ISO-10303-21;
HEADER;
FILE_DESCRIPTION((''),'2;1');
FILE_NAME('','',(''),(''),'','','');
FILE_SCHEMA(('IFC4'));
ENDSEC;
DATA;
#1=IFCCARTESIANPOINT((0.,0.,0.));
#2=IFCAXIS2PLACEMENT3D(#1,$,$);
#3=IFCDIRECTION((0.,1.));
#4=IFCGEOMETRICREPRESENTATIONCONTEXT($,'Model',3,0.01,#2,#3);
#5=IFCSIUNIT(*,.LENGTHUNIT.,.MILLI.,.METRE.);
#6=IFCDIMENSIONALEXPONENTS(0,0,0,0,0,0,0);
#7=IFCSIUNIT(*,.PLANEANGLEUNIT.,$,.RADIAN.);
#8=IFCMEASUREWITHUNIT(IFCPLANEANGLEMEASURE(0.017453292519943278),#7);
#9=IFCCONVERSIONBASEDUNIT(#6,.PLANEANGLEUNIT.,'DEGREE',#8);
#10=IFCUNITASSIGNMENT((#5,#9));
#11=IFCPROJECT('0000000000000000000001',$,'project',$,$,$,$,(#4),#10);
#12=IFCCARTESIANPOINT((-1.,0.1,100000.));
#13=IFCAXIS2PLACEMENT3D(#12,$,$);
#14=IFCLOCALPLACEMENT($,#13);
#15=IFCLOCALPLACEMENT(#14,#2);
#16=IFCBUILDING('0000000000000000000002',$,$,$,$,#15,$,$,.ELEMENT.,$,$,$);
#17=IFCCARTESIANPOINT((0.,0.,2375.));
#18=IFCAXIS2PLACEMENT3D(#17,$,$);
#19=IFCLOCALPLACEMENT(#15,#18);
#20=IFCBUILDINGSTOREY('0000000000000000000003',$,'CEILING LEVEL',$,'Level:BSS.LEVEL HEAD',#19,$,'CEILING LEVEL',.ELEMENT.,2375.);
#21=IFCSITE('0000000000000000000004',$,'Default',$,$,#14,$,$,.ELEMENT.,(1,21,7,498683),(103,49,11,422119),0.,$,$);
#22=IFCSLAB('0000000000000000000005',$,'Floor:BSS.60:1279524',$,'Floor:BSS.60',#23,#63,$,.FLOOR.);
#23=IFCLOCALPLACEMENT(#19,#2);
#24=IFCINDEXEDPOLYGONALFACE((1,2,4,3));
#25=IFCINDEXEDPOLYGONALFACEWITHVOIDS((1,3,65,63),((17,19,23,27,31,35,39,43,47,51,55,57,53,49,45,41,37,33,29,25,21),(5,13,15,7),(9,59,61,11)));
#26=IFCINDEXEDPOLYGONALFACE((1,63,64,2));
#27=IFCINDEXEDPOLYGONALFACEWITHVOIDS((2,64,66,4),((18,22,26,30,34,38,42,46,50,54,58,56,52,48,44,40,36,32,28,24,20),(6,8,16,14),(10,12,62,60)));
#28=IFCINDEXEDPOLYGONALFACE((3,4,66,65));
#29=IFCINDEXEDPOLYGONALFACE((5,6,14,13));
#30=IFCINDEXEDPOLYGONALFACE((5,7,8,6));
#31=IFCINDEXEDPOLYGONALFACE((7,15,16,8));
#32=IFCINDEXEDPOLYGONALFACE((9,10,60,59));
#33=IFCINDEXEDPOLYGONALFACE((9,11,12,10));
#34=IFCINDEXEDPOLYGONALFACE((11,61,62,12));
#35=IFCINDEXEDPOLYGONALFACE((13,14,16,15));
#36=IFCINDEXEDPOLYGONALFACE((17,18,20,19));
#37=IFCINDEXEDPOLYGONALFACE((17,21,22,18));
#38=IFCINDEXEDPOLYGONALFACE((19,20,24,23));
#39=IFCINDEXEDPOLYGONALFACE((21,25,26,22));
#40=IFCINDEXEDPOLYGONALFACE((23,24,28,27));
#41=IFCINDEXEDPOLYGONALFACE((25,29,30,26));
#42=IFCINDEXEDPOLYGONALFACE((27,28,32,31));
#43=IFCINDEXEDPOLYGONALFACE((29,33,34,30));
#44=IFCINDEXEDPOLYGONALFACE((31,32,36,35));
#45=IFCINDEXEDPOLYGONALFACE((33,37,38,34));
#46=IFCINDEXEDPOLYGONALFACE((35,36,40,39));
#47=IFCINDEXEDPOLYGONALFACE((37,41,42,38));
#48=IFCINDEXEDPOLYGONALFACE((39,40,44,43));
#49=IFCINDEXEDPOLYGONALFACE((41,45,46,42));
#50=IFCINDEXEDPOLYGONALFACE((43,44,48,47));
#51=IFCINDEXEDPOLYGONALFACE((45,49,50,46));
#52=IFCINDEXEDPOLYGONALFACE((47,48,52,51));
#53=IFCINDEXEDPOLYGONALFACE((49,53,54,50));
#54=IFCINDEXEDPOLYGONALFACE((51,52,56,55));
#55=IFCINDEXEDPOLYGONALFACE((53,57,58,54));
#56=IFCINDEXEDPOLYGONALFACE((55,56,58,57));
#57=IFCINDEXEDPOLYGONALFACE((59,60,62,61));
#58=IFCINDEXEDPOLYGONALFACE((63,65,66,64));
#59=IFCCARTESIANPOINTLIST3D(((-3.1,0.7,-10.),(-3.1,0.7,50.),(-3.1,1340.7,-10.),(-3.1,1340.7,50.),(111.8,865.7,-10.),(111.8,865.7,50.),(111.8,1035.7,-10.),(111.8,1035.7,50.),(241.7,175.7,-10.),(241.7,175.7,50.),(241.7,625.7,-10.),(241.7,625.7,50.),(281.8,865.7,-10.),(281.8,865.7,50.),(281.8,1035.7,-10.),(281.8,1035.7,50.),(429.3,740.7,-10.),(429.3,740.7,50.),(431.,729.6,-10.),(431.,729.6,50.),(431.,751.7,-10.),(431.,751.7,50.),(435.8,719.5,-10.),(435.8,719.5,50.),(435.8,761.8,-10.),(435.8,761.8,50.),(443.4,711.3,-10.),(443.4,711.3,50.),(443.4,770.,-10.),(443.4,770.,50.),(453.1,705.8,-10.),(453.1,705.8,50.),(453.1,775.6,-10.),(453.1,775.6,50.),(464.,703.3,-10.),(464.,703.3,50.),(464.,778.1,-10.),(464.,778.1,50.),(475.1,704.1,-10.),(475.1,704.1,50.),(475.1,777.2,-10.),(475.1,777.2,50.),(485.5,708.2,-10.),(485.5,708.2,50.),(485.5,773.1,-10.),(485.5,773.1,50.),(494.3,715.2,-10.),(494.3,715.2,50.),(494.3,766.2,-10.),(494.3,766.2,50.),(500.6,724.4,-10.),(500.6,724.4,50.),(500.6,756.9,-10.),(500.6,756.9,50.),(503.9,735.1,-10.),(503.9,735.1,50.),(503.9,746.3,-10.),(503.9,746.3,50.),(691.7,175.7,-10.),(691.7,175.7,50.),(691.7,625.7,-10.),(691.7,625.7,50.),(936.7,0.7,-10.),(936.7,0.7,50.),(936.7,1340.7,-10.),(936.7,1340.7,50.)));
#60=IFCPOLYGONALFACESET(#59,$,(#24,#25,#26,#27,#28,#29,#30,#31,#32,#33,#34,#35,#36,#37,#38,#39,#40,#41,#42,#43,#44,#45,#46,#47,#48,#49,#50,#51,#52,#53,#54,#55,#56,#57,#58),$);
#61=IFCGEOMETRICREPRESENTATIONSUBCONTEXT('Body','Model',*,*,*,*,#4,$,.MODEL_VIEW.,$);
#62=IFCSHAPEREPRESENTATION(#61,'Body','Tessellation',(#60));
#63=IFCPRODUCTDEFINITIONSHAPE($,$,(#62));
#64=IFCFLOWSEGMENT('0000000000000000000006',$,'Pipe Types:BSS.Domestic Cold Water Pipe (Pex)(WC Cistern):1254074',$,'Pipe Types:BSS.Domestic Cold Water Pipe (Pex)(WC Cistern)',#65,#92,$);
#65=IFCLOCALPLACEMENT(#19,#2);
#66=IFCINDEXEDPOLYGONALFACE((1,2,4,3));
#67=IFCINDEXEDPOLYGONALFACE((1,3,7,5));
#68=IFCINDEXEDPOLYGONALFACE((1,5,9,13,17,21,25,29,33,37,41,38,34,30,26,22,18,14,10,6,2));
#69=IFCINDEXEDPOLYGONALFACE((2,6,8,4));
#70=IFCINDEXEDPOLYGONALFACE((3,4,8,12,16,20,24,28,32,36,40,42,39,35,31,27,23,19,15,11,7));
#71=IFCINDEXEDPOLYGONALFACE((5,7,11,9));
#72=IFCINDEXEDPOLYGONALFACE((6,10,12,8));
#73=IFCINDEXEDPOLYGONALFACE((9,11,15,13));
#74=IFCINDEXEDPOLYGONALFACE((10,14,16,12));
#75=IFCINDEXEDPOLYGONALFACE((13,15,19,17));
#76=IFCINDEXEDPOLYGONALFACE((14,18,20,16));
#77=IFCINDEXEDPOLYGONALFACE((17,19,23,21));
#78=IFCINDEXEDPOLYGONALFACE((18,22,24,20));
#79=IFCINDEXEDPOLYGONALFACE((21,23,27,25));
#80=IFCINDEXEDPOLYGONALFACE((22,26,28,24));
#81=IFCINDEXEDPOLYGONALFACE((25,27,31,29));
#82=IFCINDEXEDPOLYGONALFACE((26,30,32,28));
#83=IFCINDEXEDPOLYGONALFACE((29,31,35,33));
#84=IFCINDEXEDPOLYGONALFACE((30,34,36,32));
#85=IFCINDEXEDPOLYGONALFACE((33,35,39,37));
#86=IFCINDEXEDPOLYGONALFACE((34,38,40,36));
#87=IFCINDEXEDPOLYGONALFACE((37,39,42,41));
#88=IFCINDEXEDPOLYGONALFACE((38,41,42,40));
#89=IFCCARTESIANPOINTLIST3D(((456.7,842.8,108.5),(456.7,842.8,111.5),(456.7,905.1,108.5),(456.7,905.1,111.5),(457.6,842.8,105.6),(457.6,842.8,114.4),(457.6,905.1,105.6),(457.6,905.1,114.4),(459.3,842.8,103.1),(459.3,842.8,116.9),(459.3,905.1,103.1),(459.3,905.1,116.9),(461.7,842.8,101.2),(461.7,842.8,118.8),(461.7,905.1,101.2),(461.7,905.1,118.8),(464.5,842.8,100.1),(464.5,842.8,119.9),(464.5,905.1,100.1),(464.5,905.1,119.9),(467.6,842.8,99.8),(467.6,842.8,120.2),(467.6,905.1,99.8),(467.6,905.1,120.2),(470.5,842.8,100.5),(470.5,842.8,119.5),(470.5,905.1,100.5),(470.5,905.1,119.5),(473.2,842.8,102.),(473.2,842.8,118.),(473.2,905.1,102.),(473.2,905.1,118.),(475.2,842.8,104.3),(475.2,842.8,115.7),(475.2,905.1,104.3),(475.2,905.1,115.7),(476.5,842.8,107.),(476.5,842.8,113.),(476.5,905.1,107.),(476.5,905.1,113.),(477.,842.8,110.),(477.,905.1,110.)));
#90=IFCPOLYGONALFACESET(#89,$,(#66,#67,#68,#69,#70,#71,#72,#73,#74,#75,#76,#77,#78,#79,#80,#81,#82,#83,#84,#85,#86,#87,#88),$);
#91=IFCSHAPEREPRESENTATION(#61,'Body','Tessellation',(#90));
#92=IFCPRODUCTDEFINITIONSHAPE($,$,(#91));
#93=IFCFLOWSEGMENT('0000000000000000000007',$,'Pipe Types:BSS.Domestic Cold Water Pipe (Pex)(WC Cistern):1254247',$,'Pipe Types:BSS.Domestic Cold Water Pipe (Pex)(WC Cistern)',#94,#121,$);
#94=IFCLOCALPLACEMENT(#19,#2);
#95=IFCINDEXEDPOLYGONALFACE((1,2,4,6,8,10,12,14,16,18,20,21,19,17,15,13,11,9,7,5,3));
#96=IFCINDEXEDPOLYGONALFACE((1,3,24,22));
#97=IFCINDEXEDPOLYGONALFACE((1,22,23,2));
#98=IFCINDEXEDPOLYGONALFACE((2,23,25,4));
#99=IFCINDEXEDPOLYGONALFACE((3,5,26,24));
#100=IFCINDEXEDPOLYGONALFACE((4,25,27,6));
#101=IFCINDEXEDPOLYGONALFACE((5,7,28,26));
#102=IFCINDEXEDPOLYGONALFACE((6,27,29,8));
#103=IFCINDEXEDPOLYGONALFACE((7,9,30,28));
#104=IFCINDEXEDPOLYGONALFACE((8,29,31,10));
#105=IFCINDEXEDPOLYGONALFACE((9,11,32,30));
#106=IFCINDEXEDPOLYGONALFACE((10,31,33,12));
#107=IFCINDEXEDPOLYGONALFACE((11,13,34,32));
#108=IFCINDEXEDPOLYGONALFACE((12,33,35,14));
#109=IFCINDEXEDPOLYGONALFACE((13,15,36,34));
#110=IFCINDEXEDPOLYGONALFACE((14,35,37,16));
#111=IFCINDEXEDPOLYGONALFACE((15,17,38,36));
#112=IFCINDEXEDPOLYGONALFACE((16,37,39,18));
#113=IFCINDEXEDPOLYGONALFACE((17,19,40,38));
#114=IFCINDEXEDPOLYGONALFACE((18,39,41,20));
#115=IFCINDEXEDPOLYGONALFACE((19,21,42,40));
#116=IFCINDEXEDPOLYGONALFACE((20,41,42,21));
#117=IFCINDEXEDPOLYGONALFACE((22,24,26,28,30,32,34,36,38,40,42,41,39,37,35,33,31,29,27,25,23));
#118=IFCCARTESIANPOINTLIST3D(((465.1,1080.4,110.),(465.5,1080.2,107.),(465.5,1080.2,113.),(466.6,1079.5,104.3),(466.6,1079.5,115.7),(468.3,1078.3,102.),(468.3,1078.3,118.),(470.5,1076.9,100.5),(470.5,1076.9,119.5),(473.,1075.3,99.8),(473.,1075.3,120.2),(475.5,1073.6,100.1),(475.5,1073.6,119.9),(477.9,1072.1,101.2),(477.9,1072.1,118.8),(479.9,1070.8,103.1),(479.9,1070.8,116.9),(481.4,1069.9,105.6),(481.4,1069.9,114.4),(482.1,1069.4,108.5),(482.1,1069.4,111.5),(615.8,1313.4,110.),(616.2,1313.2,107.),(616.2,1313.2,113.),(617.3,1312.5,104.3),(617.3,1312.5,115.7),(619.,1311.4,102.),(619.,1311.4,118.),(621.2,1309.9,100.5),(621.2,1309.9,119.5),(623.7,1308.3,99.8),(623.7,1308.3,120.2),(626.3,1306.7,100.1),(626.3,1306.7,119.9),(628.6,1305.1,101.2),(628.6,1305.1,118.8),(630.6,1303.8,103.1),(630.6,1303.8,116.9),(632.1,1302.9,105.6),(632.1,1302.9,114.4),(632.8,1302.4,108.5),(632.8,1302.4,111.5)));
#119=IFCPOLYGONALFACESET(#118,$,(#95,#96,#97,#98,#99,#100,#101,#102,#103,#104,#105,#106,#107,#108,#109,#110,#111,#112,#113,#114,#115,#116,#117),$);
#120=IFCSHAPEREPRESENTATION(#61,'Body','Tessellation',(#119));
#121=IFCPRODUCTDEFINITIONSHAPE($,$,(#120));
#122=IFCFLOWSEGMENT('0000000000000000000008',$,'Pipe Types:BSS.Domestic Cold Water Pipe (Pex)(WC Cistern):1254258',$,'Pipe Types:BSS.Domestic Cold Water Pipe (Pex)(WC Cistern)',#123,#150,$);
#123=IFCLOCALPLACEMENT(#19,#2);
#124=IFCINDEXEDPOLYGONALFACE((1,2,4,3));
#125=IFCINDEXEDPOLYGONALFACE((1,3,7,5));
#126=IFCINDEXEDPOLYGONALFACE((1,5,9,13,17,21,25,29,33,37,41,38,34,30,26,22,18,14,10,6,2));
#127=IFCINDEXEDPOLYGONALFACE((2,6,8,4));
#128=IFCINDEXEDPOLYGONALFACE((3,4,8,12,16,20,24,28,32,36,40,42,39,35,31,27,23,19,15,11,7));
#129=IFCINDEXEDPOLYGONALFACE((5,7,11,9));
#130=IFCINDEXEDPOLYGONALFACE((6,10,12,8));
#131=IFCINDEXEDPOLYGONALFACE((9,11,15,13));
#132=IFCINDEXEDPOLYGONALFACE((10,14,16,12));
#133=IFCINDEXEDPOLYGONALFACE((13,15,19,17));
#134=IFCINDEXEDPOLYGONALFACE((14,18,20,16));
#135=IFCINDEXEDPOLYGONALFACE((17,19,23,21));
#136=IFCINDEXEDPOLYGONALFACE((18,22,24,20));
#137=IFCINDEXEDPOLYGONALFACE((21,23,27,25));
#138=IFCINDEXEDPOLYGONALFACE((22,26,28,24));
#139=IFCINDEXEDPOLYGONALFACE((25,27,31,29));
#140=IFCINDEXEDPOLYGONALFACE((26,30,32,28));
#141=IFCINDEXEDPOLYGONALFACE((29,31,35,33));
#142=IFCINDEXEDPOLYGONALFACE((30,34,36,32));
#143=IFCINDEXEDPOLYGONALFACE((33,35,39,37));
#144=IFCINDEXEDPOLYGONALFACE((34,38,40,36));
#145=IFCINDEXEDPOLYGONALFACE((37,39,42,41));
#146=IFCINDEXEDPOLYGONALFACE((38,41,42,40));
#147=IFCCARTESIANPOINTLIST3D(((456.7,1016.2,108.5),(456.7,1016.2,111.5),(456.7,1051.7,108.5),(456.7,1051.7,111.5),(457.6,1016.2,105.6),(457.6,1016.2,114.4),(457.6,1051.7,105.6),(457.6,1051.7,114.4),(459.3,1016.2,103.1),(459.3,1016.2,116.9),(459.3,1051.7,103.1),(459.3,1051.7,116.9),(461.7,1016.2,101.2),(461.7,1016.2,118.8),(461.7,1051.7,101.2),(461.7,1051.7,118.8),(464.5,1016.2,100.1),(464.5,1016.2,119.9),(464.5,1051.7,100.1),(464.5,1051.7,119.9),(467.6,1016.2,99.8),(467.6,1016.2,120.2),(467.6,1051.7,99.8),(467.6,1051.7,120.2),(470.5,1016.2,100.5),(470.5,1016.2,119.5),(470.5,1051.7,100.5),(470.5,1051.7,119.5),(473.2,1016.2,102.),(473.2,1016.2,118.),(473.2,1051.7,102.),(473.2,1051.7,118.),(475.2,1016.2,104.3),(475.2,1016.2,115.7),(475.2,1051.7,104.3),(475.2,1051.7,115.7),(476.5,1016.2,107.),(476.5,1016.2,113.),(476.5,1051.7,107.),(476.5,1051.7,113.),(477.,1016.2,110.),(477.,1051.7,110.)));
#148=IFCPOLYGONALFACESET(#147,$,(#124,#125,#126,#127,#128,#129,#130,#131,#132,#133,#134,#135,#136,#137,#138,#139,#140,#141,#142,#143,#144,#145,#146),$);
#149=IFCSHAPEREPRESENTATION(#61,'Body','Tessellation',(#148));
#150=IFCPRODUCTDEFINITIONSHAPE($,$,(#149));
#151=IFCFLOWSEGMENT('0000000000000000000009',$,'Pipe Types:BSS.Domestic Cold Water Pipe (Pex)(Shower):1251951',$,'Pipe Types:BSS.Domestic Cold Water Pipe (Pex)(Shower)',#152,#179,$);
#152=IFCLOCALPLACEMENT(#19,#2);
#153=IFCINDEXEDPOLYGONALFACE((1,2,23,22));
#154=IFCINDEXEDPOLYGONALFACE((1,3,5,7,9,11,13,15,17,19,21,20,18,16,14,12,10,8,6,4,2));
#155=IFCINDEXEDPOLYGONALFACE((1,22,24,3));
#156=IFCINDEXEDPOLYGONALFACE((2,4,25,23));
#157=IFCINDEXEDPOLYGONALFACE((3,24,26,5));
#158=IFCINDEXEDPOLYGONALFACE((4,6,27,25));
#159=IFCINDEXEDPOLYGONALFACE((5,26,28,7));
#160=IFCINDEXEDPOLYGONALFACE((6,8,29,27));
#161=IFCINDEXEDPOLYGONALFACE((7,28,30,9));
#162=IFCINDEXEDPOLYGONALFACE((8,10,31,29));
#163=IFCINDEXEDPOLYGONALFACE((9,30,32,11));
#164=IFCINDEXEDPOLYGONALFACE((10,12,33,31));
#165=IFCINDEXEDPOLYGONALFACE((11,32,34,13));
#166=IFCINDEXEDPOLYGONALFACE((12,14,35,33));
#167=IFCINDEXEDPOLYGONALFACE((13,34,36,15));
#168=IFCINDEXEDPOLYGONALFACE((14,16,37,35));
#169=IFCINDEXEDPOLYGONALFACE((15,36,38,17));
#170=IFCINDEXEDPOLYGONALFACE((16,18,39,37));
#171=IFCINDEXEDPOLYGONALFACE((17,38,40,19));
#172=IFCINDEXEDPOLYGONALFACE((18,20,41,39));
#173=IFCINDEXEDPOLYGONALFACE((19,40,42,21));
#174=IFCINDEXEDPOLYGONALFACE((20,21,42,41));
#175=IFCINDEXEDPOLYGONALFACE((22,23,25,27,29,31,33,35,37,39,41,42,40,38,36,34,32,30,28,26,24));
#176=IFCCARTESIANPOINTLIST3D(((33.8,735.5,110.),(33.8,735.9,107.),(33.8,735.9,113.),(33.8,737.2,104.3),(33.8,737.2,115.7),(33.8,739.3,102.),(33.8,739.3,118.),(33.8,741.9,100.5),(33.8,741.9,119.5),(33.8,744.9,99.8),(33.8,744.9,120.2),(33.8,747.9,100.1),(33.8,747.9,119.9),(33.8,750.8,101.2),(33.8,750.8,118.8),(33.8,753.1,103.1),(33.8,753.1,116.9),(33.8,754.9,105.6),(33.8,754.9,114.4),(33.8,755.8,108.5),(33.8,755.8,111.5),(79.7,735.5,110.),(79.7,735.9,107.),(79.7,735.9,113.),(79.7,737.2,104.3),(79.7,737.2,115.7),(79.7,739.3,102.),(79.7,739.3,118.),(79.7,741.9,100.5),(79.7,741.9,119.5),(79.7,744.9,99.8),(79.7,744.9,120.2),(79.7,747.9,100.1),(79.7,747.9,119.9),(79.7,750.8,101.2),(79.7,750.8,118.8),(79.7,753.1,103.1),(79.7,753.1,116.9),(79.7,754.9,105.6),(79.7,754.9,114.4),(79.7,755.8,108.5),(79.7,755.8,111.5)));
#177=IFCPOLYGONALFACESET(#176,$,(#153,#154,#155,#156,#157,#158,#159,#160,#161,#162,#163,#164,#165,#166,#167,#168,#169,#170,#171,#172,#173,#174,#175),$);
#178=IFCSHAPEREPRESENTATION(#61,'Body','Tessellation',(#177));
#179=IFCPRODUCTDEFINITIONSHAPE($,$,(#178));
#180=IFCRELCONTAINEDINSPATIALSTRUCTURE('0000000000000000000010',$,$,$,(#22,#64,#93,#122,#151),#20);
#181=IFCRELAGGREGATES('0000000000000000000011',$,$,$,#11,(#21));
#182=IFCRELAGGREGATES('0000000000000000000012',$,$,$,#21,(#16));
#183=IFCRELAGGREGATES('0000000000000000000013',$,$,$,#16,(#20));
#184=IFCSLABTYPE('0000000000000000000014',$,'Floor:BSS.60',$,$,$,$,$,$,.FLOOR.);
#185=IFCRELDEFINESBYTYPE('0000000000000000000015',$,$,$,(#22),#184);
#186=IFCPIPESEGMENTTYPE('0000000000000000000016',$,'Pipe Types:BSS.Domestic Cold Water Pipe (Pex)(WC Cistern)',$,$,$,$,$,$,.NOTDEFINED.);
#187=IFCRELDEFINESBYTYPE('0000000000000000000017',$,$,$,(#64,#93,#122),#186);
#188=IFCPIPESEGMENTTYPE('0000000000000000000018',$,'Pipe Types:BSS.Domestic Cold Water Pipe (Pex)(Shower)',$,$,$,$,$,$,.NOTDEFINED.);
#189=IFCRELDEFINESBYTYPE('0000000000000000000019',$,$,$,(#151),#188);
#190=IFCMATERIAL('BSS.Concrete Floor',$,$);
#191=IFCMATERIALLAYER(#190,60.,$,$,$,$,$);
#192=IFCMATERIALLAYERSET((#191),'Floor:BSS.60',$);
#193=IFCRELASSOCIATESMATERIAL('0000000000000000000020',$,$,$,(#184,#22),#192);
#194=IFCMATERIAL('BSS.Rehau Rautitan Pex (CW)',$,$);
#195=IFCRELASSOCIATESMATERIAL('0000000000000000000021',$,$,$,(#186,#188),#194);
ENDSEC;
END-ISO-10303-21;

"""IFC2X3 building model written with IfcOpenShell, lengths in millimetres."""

from ifc_helpers import new_model, entity, si_unit, converted_unit, direction, frame, frame_2d, origin, origin_2d_with_axis, place, context, subcontext, project, spatial, rectangle, circle, extrude, material, layer, layer_set, layer_usage, type_object, element, save


model = new_model("IFC2X3")

# Units and contexts
model_context = context("Model", 3, precision=0.01, world=origin(), true_north=direction((0.0, 1.0)))
body_context = subcontext(model_context, "Body", "Model", "MODEL_VIEW")
ifc_project = project(units=[si_unit("LENGTHUNIT", "METRE", prefix="MILLI"), converted_unit("PLANEANGLEUNIT", "DEGREE", entity("IfcPlaneAngleMeasure", 0.017453292519943278), si_unit("PLANEANGLEUNIT", "RADIAN"), dimensions=[0, 0, 0, 0, 0, 0, 0])], contexts=[model_context])

# Site, building, storey
site_placement = place(None, frame((-1.0, 0.1, 100000.0)))
site = spatial("IfcSite", under=ifc_project, at=site_placement, Name="Default", CompositionType="ELEMENT", RefLatitude=(1, 21, 7, 498683), RefLongitude=(103, 49, 11, 422119), RefElevation=0.0)
building_placement = place(site_placement, origin())
building = spatial("IfcBuilding", under=site, at=building_placement, CompositionType="ELEMENT")
storey_placement = place(building_placement, frame((0.0, 0.0, 2375.0)))
storey = spatial("IfcBuildingStorey", under=building, at=storey_placement, Name="CEILING LEVEL", ObjectType="Level:BSS.LEVEL HEAD", LongName="CEILING LEVEL", CompositionType="ELEMENT", Elevation=2375.0)

# Slab, openings
ifc_material_1 = material(Name="BSS.Concrete Floor")
ifc_layer = layer(ifc_material_1, 60.0)
ifc_layer_set = layer_set([ifc_layer], Name="Floor:BSS.60")
ifc_layer_usage = layer_usage(ifc_layer_set, "AXIS3", "POSITIVE", 0.0)
slab_type = type_object("IfcSlabType", Name="Floor:BSS.60", PredefinedType="FLOOR", material=ifc_layer_set)
slab_placement = place(storey_placement, frame((-3.1, 0.7, -10.0)))
slab = element("IfcSlab", 1, at=slab_placement, inside=storey, type_object=slab_type, material=ifc_layer_usage, Name="Floor:BSS.60:1279524", ObjectType="Floor:BSS.60", PredefinedType="FLOOR", context=body_context, shape_type="SweptSolid", body=[
    extrude(rectangle(XDim=1340.0, YDim=939.7, at=frame_2d((0.0, 0.0), x_axis=(0.0, -1.0))), frame((469.9, 670.0, 60.0), z_axis=(0.0, 0.0, -1.0), x_axis=(-1.0, 0.0, 0.0)), (0.0, 0.0, 1.0), 60.0),
])
opening_1_placement = place(slab_placement, origin())
element("IfcOpeningElement", 2, at=opening_1_placement, cuts=slab, ObjectType="Opening", context=body_context, shape_type="SweptSolid", body=[
    extrude(circle(Radius=37.5, at=frame_2d((0.0, 70.0), x_axis=(1.0, 0.0))), frame((469.9, 670.0, 60.0), z_axis=(0.0, 0.0, -1.0), x_axis=(-1.0, 0.0, 0.0)), (0.0, 0.0, 1.0), 60.0),
])
opening_2_placement = place(slab_placement, origin())
element("IfcOpeningElement", 3, at=opening_2_placement, cuts=slab, ObjectType="Opening", context=body_context, shape_type="SweptSolid", body=[
    extrude(rectangle(XDim=170.0, YDim=170.0, at=frame_2d((270.0, 280.0), x_axis=(0.0, -1.0))), frame((469.9, 670.0, 60.0), z_axis=(0.0, 0.0, -1.0), x_axis=(-1.0, 0.0, 0.0)), (0.0, 0.0, 1.0), 60.0),
])
opening_3_placement = place(slab_placement, origin())
element("IfcOpeningElement", 4, at=opening_3_placement, cuts=slab, ObjectType="Opening", context=body_context, shape_type="SweptSolid", body=[
    extrude(rectangle(XDim=450.0, YDim=450.0, at=frame_2d((0.1, -270.0), x_axis=(0.0, -1.0))), frame((469.9, 670.0, 60.0), z_axis=(0.0, 0.0, -1.0), x_axis=(-1.0, 0.0, 0.0)), (0.0, 0.0, 1.0), 60.0),
])

# Flow segments
ifc_material_2 = material(Name="BSS.Rehau Rautitan Pex (CW)")
pipe_segment_type_1 = type_object("IfcPipeSegmentType", Name="Pipe Types:BSS.Domestic Cold Water Pipe (Pex)(WC Cistern)", PredefinedType="NOTDEFINED", material=ifc_material_2)
flow_segment_1_placement = place(storey_placement, origin())
element("IfcFlowSegment", 5, at=flow_segment_1_placement, inside=storey, type_object=pipe_segment_type_1, Name="Pipe Types:BSS.Domestic Cold Water Pipe (Pex)(WC Cistern):1254074", ObjectType="Pipe Types:BSS.Domestic Cold Water Pipe (Pex)(WC Cistern)", context=body_context, shape_type="SweptSolid", body=[
    extrude(circle(Radius=10.2, at=frame_2d((0.0, 0.0), x_axis=(1.0, 0.0))), frame((466.8, 842.8, 110.0), z_axis=(0.0, 1.0, 0.0), x_axis=(1.0, 0.0, 0.0)), (0.0, 0.0, 1.0), 62.3),
])
flow_segment_2_placement = place(storey_placement, origin())
element("IfcFlowSegment", 6, at=flow_segment_2_placement, inside=storey, type_object=pipe_segment_type_1, Name="Pipe Types:BSS.Domestic Cold Water Pipe (Pex)(WC Cistern):1254247", ObjectType="Pipe Types:BSS.Domestic Cold Water Pipe (Pex)(WC Cistern)", context=body_context, shape_type="SweptSolid", body=[
    extrude(circle(Radius=10.2, at=origin_2d_with_axis()), frame((473.6, 1074.9, 110.0), z_axis=(0.543056, 0.839696, 0.0), x_axis=(-0.839696, 0.543056, 0.0)), (0.0, 0.0, 1.0), 277.5),
])
flow_segment_3_placement = place(storey_placement, origin())
element("IfcFlowSegment", 7, at=flow_segment_3_placement, inside=storey, type_object=pipe_segment_type_1, Name="Pipe Types:BSS.Domestic Cold Water Pipe (Pex)(WC Cistern):1254258", ObjectType="Pipe Types:BSS.Domestic Cold Water Pipe (Pex)(WC Cistern)", context=body_context, shape_type="SweptSolid", body=[
    extrude(circle(Radius=10.2, at=origin_2d_with_axis()), frame((466.8, 1016.2, 110.0), z_axis=(0.0, 1.0, 0.0), x_axis=(1.0, 0.0, 0.0)), (0.0, 0.0, 1.0), 35.5),
])
pipe_segment_type_2 = type_object("IfcPipeSegmentType", Name="Pipe Types:BSS.Domestic Cold Water Pipe (Pex)(Shower)", PredefinedType="NOTDEFINED", material=ifc_material_2)
flow_segment_4_placement = place(storey_placement, origin())
element("IfcFlowSegment", 8, at=flow_segment_4_placement, inside=storey, type_object=pipe_segment_type_2, Name="Pipe Types:BSS.Domestic Cold Water Pipe (Pex)(Shower):1251951", ObjectType="Pipe Types:BSS.Domestic Cold Water Pipe (Pex)(Shower)", context=body_context, shape_type="SweptSolid", body=[
    extrude(circle(Radius=10.2, at=origin_2d_with_axis()), frame((33.8, 745.7, 110.0), z_axis=(1.0, 0.0, 0.0), x_axis=(0.0, -1.0, 0.0)), (0.0, 0.0, 1.0), 45.9),
])

save(model, "model.ifc")
